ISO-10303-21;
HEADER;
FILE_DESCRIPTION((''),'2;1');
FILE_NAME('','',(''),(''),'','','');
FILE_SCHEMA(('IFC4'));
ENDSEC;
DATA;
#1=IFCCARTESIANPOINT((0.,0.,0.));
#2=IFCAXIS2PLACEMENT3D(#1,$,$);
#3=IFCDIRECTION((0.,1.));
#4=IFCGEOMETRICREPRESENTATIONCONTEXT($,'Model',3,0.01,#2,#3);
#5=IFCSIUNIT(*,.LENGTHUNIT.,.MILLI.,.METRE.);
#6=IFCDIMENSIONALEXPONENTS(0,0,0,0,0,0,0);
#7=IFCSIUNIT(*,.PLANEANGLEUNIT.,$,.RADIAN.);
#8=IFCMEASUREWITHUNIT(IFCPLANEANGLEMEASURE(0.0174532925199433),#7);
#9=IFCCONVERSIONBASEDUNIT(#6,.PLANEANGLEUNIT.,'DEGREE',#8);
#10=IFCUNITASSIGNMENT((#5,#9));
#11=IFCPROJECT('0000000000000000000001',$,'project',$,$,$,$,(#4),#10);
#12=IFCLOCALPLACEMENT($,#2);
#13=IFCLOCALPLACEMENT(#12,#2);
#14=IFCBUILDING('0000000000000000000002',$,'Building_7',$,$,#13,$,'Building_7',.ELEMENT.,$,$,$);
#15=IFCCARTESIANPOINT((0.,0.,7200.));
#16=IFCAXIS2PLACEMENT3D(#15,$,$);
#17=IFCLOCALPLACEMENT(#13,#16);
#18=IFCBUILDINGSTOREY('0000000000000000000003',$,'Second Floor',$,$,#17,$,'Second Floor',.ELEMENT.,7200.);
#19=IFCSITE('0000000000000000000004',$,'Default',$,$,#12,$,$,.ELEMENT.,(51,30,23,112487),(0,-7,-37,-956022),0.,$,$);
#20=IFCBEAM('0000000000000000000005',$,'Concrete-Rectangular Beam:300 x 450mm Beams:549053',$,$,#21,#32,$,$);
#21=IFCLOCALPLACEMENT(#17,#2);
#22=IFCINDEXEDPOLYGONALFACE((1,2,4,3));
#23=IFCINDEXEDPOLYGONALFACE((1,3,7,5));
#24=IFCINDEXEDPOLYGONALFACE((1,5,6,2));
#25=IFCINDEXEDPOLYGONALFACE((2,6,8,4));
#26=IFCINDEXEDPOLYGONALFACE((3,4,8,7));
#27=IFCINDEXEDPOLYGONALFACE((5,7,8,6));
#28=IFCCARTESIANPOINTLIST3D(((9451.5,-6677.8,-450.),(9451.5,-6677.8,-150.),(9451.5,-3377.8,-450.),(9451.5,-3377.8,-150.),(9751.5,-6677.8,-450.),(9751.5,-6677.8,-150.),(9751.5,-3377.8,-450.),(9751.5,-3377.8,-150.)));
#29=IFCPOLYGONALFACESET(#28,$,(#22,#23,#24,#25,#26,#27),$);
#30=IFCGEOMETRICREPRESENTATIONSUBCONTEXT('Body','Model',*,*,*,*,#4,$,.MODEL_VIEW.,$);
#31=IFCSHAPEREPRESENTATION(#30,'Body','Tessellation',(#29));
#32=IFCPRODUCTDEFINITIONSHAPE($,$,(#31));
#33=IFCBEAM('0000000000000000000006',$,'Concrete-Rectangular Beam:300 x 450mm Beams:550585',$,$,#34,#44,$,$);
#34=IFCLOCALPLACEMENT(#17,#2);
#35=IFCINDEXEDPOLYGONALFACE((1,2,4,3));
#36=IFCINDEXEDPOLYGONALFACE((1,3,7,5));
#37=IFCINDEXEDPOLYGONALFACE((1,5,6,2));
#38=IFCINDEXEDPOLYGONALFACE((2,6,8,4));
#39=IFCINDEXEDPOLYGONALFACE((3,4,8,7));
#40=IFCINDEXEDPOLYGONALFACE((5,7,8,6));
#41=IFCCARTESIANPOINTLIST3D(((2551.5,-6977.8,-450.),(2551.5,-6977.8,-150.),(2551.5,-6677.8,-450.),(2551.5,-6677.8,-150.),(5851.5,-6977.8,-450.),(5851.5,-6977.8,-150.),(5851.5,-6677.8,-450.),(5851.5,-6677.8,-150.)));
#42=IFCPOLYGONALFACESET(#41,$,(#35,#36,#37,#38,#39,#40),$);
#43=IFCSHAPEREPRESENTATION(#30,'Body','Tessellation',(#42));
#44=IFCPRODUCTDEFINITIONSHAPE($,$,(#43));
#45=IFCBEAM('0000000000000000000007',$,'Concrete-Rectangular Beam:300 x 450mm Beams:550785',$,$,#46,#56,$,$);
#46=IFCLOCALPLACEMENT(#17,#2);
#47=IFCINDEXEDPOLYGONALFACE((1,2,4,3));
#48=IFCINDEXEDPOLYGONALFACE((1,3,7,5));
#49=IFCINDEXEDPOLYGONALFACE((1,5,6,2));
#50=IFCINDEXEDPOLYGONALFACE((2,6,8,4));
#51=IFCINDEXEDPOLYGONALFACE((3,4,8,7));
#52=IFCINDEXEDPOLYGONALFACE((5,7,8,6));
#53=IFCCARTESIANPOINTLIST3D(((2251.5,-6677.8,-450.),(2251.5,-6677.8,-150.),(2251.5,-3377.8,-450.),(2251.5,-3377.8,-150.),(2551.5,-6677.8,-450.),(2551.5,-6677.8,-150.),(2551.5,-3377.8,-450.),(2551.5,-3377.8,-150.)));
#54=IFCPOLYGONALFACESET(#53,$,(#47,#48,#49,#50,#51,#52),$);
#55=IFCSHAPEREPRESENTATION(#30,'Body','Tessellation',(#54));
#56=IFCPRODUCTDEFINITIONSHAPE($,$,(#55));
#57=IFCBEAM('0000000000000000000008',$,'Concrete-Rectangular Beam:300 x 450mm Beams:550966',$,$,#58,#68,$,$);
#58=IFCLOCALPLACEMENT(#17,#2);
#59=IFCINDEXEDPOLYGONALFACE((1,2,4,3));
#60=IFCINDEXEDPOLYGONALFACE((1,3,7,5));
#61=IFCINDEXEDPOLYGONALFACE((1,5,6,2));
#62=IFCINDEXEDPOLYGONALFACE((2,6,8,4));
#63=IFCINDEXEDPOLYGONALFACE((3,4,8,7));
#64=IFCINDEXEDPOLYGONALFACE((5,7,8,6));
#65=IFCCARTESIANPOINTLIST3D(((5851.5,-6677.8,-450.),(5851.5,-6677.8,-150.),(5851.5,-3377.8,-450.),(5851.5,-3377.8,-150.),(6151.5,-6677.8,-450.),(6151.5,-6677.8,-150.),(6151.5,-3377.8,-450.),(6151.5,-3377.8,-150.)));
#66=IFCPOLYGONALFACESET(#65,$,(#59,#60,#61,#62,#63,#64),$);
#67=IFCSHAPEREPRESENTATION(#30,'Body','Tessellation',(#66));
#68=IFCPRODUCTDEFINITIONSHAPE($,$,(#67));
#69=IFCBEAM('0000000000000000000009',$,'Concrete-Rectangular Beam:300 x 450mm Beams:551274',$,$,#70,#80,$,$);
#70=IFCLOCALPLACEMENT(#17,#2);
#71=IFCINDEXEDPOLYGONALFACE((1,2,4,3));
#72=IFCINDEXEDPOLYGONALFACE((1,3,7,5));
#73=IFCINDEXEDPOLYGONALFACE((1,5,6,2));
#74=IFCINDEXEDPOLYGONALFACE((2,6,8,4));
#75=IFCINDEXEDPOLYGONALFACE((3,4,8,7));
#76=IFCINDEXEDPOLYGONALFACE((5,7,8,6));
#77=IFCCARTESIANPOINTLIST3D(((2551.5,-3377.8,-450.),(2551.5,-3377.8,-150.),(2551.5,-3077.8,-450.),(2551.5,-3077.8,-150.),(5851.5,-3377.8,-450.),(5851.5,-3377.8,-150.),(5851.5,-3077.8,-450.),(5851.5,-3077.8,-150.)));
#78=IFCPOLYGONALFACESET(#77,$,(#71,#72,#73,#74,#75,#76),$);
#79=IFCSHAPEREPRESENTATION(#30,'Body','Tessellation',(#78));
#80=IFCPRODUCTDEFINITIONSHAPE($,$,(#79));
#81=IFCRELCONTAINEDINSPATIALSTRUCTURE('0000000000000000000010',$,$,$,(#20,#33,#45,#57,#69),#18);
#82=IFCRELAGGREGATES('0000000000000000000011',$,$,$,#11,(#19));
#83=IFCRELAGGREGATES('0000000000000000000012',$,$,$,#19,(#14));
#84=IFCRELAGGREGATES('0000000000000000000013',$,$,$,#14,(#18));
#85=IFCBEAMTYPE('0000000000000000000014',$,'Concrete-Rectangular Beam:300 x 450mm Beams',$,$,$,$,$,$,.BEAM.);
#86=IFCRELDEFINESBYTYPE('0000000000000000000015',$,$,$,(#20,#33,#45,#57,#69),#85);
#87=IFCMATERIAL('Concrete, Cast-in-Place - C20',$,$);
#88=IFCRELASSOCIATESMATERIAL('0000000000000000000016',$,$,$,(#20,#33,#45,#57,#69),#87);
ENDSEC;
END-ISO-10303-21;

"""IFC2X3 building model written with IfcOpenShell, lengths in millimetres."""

from ifc_helpers import new_model, entity, si_unit, converted_unit, direction, frame, frame_2d, origin, place, context, subcontext, project, spatial, rectangle, extrude, material, type_object, element, save


model = new_model("IFC2X3")

# Units and contexts
model_context = context("Model", 3, precision=0.01, world=origin(), true_north=direction((0.0, 1.0)))
body_context = subcontext(model_context, "Body", "Model", "MODEL_VIEW")
ifc_project = project(units=[si_unit("LENGTHUNIT", "METRE", prefix="MILLI"), converted_unit("PLANEANGLEUNIT", "DEGREE", entity("IfcPlaneAngleMeasure", 0.0174532925199433), si_unit("PLANEANGLEUNIT", "RADIAN"), dimensions=[0, 0, 0, 0, 0, 0, 0])], contexts=[model_context])

# Site, building, storey
site_placement = place(None, origin())
site = spatial("IfcSite", under=ifc_project, at=site_placement, Name="Default", CompositionType="ELEMENT", RefLatitude=(51, 30, 23, 112487), RefLongitude=(0, -7, -37, -956022), RefElevation=0.0)
building_placement = place(site_placement, origin())
building = spatial("IfcBuilding", under=site, at=building_placement, Name="Building_7", LongName="Building_7", CompositionType="ELEMENT")
storey_placement = place(building_placement, frame((0.0, 0.0, 7200.0)))
storey = spatial("IfcBuildingStorey", under=building, at=storey_placement, Name="Second Floor", LongName="Second Floor", CompositionType="ELEMENT", Elevation=7200.0)

# Beams
ifc_material_1 = material(Name="Concrete, Cast-in-Place - C20")
beam_type = type_object("IfcBeamType", Name="Concrete-Rectangular Beam:300 x 450mm Beams", PredefinedType="BEAM")
beam_1_placement = place(storey_placement, frame((9601.5, -3227.8, 0.0), z_axis=(0.0, 0.0, 1.0), x_axis=(0.0, -1.0, 0.0)))
element("IfcBeam", 1, at=beam_1_placement, inside=storey, type_object=beam_type, material=ifc_material_1, Name="Concrete-Rectangular Beam:300 x 450mm Beams:549053", context=body_context, shape_type="SweptSolid", body=[
    extrude(rectangle(XDim=300.0, YDim=300.0, at=frame_2d((0.0, 0.0), x_axis=(1.0, 0.0))), frame((150.0, 0.0, -300.0), z_axis=(1.0, 0.0, 0.0), x_axis=(0.0, 0.0, -1.0)), (0.0, 0.0, 1.0), 3300.0),
])
beam_2_placement = place(storey_placement, frame((6001.5, -6827.8, 0.0), z_axis=(0.0, 0.0, 1.0), x_axis=(-1.0, 0.0, 0.0)))
element("IfcBeam", 2, at=beam_2_placement, inside=storey, type_object=beam_type, material=ifc_material_1, Name="Concrete-Rectangular Beam:300 x 450mm Beams:550585", context=body_context, shape_type="SweptSolid", body=[
    extrude(rectangle(XDim=300.0, YDim=300.0, at=frame_2d((0.0, 0.0), x_axis=(1.0, 0.0))), frame((150.0, 0.0, -300.0), z_axis=(1.0, 0.0, 0.0), x_axis=(0.0, 0.0, -1.0)), (0.0, 0.0, 1.0), 3300.0),
])
beam_3_placement = place(storey_placement, frame((2401.5, -3077.8, 0.0), z_axis=(0.0, 0.0, 1.0), x_axis=(0.0, -1.0, 0.0)))
element("IfcBeam", 3, at=beam_3_placement, inside=storey, type_object=beam_type, material=ifc_material_1, Name="Concrete-Rectangular Beam:300 x 450mm Beams:550785", context=body_context, shape_type="SweptSolid", body=[
    extrude(rectangle(XDim=300.0, YDim=300.0, at=frame_2d((0.0, 0.0), x_axis=(1.0, 0.0))), frame((300.0, 0.0, -300.0), z_axis=(1.0, 0.0, 0.0), x_axis=(0.0, 0.0, -1.0)), (0.0, 0.0, 1.0), 3300.0),
])
beam_4_placement = place(storey_placement, frame((6001.5, -3227.8, 0.0), z_axis=(0.0, 0.0, 1.0), x_axis=(0.0, -1.0, 0.0)))
element("IfcBeam", 4, at=beam_4_placement, inside=storey, type_object=beam_type, material=ifc_material_1, Name="Concrete-Rectangular Beam:300 x 450mm Beams:550966", context=body_context, shape_type="SweptSolid", body=[
    extrude(rectangle(XDim=300.0, YDim=300.0, at=frame_2d((0.0, 0.0), x_axis=(1.0, 0.0))), frame((150.0, 0.0, -300.0), z_axis=(1.0, 0.0, 0.0), x_axis=(0.0, 0.0, -1.0)), (0.0, 0.0, 1.0), 3300.0),
])
beam_5_placement = place(storey_placement, frame((6001.5, -3227.8, 0.0), z_axis=(0.0, 0.0, 1.0), x_axis=(-1.0, 0.0, 0.0)))
element("IfcBeam", 5, at=beam_5_placement, inside=storey, type_object=beam_type, material=ifc_material_1, Name="Concrete-Rectangular Beam:300 x 450mm Beams:551274", context=body_context, shape_type="SweptSolid", body=[
    extrude(rectangle(XDim=300.0, YDim=300.0, at=frame_2d((0.0, 0.0), x_axis=(1.0, 0.0))), frame((150.0, 0.0, -300.0), z_axis=(1.0, 0.0, 0.0), x_axis=(0.0, 0.0, -1.0)), (0.0, 0.0, 1.0), 3300.0),
])

save(model, "model.ifc")
